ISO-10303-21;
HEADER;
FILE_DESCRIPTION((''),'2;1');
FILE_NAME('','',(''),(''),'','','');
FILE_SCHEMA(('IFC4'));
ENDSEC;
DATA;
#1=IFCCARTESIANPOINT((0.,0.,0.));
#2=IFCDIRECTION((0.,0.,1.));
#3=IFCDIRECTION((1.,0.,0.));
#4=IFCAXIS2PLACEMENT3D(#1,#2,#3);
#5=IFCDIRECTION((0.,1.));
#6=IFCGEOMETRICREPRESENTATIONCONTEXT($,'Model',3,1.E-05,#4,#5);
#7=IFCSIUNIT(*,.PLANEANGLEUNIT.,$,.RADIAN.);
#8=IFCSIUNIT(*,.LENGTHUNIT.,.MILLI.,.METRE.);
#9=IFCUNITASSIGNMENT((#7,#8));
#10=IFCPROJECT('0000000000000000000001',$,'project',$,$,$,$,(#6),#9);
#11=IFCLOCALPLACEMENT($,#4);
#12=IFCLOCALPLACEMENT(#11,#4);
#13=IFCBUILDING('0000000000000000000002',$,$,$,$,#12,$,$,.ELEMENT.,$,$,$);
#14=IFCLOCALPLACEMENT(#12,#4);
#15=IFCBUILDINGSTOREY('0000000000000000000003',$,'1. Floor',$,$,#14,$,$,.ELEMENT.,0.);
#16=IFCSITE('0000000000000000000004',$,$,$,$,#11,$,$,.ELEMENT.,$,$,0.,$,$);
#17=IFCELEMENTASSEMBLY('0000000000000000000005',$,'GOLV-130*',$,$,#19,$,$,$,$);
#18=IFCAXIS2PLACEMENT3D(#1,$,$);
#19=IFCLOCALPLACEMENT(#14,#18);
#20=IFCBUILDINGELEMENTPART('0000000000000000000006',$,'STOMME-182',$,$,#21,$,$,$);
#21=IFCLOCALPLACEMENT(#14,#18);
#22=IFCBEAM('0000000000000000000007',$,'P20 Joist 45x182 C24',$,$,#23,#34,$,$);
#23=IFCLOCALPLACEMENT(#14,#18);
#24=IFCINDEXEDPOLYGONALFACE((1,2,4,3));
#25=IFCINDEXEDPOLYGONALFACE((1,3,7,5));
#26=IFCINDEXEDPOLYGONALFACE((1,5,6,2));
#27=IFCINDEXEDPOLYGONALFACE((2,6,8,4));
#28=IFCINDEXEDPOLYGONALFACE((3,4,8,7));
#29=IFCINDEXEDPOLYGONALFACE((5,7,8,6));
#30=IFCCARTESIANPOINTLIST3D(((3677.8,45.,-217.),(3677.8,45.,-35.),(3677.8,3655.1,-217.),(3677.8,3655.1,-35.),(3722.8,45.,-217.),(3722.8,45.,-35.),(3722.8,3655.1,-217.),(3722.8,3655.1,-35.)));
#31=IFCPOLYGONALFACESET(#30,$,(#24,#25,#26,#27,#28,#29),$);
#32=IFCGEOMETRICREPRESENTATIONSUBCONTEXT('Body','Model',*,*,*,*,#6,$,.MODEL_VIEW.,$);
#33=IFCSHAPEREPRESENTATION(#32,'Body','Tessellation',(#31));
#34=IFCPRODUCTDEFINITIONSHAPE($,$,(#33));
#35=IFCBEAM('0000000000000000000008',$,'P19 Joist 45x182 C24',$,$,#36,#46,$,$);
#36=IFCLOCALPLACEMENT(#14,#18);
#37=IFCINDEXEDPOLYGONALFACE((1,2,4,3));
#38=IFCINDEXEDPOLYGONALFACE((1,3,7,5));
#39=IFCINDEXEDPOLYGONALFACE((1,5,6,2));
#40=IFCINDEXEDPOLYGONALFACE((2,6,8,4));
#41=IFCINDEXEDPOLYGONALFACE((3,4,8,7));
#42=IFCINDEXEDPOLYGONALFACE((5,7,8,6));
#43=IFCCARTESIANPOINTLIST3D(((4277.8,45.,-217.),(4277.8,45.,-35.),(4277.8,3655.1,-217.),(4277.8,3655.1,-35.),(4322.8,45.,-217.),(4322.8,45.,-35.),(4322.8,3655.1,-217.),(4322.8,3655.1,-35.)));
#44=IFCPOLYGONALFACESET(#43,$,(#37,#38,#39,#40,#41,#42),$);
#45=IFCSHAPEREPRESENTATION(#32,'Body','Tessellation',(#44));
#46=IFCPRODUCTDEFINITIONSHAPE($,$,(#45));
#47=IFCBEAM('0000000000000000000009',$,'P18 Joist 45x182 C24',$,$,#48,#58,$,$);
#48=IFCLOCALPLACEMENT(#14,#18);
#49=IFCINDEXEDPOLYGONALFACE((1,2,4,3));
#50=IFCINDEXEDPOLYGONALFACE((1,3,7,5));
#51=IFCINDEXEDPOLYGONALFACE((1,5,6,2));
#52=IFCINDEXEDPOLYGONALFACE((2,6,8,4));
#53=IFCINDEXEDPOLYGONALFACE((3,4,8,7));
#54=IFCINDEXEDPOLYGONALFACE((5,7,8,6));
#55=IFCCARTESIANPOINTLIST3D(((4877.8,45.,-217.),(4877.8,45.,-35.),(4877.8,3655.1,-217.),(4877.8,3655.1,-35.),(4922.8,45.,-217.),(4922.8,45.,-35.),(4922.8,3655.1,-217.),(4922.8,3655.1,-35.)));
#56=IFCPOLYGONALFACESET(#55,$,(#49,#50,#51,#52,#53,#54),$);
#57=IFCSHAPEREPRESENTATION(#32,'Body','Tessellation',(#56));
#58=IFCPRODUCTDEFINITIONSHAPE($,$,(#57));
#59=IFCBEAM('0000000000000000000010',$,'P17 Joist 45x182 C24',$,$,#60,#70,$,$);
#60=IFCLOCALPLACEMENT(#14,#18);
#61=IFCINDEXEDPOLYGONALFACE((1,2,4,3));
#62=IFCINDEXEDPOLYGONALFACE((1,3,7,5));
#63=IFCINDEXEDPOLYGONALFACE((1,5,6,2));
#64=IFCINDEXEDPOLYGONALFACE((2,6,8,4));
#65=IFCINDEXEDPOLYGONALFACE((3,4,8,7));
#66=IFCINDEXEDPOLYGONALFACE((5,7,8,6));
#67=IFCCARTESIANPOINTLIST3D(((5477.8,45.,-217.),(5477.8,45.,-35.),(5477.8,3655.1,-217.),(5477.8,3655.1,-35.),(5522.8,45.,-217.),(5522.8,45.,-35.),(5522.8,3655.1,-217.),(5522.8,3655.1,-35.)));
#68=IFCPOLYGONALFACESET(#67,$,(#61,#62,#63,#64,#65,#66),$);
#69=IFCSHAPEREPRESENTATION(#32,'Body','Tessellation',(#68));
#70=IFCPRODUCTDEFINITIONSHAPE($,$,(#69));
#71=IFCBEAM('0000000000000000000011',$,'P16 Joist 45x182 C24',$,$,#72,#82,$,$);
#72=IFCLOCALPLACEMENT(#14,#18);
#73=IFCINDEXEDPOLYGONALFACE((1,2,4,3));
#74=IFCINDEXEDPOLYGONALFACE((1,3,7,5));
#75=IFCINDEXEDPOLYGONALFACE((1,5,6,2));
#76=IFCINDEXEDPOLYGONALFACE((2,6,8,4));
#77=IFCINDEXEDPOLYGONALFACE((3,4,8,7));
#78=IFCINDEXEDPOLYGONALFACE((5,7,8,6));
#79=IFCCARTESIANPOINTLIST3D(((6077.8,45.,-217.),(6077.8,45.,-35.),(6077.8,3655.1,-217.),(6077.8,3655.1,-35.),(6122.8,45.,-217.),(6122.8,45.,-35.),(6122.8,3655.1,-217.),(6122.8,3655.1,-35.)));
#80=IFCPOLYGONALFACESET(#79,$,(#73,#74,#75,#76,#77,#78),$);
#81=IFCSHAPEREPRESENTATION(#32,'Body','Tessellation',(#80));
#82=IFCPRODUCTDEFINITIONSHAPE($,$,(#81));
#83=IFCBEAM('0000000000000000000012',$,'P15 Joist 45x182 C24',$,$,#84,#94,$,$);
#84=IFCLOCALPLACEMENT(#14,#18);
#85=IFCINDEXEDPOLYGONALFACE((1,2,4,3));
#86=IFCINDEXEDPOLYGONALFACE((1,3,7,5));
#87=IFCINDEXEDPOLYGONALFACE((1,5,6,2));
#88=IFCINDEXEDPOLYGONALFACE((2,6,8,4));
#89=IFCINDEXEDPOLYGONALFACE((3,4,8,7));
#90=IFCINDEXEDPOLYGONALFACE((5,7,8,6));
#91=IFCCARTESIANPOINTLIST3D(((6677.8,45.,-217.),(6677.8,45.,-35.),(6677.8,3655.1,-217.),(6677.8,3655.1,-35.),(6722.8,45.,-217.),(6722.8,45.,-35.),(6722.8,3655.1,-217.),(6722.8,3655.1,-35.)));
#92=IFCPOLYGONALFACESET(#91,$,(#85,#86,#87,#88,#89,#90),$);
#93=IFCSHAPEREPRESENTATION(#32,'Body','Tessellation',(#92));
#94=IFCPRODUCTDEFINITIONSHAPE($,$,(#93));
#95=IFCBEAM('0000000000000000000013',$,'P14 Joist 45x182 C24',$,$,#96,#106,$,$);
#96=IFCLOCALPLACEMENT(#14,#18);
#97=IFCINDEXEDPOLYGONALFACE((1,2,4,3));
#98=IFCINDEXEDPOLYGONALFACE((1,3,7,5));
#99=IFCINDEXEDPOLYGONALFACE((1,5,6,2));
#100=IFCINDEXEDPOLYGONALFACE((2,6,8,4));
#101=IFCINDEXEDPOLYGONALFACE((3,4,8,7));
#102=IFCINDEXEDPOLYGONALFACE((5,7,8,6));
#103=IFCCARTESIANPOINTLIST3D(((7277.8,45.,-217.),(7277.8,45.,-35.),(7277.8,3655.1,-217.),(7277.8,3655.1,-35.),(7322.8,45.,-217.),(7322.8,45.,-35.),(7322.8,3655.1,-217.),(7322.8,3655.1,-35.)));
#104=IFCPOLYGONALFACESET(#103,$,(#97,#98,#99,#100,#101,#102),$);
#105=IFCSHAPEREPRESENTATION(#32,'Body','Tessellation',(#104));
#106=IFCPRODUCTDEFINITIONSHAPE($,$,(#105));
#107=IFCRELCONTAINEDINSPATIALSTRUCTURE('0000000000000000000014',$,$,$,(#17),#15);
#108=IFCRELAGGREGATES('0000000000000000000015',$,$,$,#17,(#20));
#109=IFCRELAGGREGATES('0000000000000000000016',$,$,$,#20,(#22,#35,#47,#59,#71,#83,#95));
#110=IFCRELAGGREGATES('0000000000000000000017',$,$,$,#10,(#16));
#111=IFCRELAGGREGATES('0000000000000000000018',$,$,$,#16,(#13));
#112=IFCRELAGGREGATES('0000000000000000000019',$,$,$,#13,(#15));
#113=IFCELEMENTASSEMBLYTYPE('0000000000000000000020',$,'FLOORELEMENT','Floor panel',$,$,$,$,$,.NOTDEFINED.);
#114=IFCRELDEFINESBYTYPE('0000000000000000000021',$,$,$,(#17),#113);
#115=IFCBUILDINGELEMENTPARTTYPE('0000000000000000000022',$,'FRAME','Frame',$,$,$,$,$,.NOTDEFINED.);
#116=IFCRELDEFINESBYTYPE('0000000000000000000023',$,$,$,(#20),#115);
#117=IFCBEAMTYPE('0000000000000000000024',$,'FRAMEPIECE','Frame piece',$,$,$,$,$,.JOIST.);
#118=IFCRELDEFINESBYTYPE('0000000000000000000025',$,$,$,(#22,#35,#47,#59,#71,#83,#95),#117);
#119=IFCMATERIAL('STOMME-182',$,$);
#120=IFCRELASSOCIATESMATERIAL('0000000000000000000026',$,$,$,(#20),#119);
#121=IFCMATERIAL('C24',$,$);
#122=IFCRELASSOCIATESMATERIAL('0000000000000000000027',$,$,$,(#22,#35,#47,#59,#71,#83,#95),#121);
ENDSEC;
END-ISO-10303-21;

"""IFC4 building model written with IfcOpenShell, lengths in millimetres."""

from ifc_helpers import new_model, si_unit, direction, frame, origin_with_axes, origin_2d_with_axis, place, context, subcontext, project, spatial, rectangle, extrude, material, type_object, element, aggregate, save


model = new_model("IFC4")

# Units and contexts
model_context = context("Model", 3, precision=1e-05, world=origin_with_axes(), true_north=direction((0.0, 1.0)))
body_context = subcontext(model_context, "Body", "Model", "MODEL_VIEW")
ifc_project = project(units=[si_unit("PLANEANGLEUNIT", "RADIAN"), si_unit("LENGTHUNIT", "METRE", prefix="MILLI")], contexts=[model_context])

# Site, building, storey
site_placement = place(None, origin_with_axes())
site = spatial("IfcSite", under=ifc_project, at=site_placement, CompositionType="ELEMENT", RefElevation=0.0)
building_placement = place(site_placement, origin_with_axes())
building = spatial("IfcBuilding", under=site, at=building_placement, CompositionType="ELEMENT")
storey_placement = place(building_placement, origin_with_axes())
storey = spatial("IfcBuildingStorey", under=building, at=storey_placement, Name="1. Floor", CompositionType="ELEMENT", Elevation=0.0)

# Element assembly, building element part, beams
element_assembly_type = type_object("IfcElementAssemblyType", Name="FLOORELEMENT", Description="Floor panel", PredefinedType="NOTDEFINED")
assembly_placement = place(storey_placement, origin_with_axes())
assembly = element("IfcElementAssembly", 1, at=assembly_placement, inside=storey, type_object=element_assembly_type, Name="GOLV-130*")
ifc_material_1 = material(Name="STOMME-182")
building_element_part_type = type_object("IfcBuildingElementPartType", Name="FRAME", Description="Frame", PredefinedType="NOTDEFINED")
building_element_part_placement = place(storey_placement, origin_with_axes())
building_element_part = element("IfcBuildingElementPart", 2, at=building_element_part_placement, type_object=building_element_part_type, material=ifc_material_1, Name="STOMME-182")
aggregate(assembly, [building_element_part])
ifc_material_2 = material(Name="C24")
beam_type_1 = type_object("IfcBeamType", Name="FRAMEPIECE", Description="Frame piece", PredefinedType="JOIST")
beam_1_placement = place(storey_placement, frame((3700.3, 3655.1, -126.0), z_axis=(0.0, -1.0, 0.0), x_axis=(1.0, 0.0, 0.0)))
beam_1 = element("IfcBeam", 3, at=beam_1_placement, type_object=beam_type_1, material=ifc_material_2, Name="P20 Joist 45x182 C24", context=body_context, shape_type="SweptSolid", body=[
    extrude(rectangle(XDim=45.0, YDim=182.0, at=origin_2d_with_axis()), origin_with_axes(), (0.0, 0.0, 1.0), 3610.1),
])
beam_2_placement = place(storey_placement, frame((4300.3, 3655.1, -126.0), z_axis=(0.0, -1.0, 0.0), x_axis=(1.0, 0.0, 0.0)))
beam_2 = element("IfcBeam", 4, at=beam_2_placement, type_object=beam_type_1, material=ifc_material_2, Name="P19 Joist 45x182 C24", context=body_context, shape_type="SweptSolid", body=[
    extrude(rectangle(XDim=45.0, YDim=182.0, at=origin_2d_with_axis()), origin_with_axes(), (0.0, 0.0, 1.0), 3610.1),
])
beam_3_placement = place(storey_placement, frame((4900.3, 3655.1, -126.0), z_axis=(0.0, -1.0, 0.0), x_axis=(1.0, 0.0, 0.0)))
beam_3 = element("IfcBeam", 5, at=beam_3_placement, type_object=beam_type_1, material=ifc_material_2, Name="P18 Joist 45x182 C24", context=body_context, shape_type="SweptSolid", body=[
    extrude(rectangle(XDim=45.0, YDim=182.0, at=origin_2d_with_axis()), origin_with_axes(), (0.0, 0.0, 1.0), 3610.1),
])
beam_4_placement = place(storey_placement, frame((5500.3, 3655.1, -126.0), z_axis=(0.0, -1.0, 0.0), x_axis=(1.0, 0.0, 0.0)))
beam_4 = element("IfcBeam", 6, at=beam_4_placement, type_object=beam_type_1, material=ifc_material_2, Name="P17 Joist 45x182 C24", context=body_context, shape_type="SweptSolid", body=[
    extrude(rectangle(XDim=45.0, YDim=182.0, at=origin_2d_with_axis()), origin_with_axes(), (0.0, 0.0, 1.0), 3610.1),
])
beam_5_placement = place(storey_placement, frame((6100.3, 3655.1, -126.0), z_axis=(0.0, -1.0, 0.0), x_axis=(1.0, 0.0, 0.0)))
beam_5 = element("IfcBeam", 7, at=beam_5_placement, type_object=beam_type_1, material=ifc_material_2, Name="P16 Joist 45x182 C24", context=body_context, shape_type="SweptSolid", body=[
    extrude(rectangle(XDim=45.0, YDim=182.0, at=origin_2d_with_axis()), origin_with_axes(), (0.0, 0.0, 1.0), 3610.1),
])
beam_6_placement = place(storey_placement, frame((6700.3, 3655.1, -126.0), z_axis=(0.0, -1.0, 0.0), x_axis=(1.0, 0.0, 0.0)))
beam_6 = element("IfcBeam", 8, at=beam_6_placement, type_object=beam_type_1, material=ifc_material_2, Name="P15 Joist 45x182 C24", context=body_context, shape_type="SweptSolid", body=[
    extrude(rectangle(XDim=45.0, YDim=182.0, at=origin_2d_with_axis()), origin_with_axes(), (0.0, 0.0, 1.0), 3610.1),
])
beam_7_placement = place(storey_placement, frame((7300.3, 3655.1, -126.0), z_axis=(0.0, -1.0, 0.0), x_axis=(1.0, 0.0, 0.0)))
beam_7 = element("IfcBeam", 9, at=beam_7_placement, type_object=beam_type_1, material=ifc_material_2, Name="P14 Joist 45x182 C24", context=body_context, shape_type="SweptSolid", body=[
    extrude(rectangle(XDim=45.0, YDim=182.0, at=origin_2d_with_axis()), origin_with_axes(), (0.0, 0.0, 1.0), 3610.1),
])
aggregate(building_element_part, [beam_1, beam_2, beam_3, beam_4, beam_5, beam_6, beam_7])

save(model, "model.ifc")
